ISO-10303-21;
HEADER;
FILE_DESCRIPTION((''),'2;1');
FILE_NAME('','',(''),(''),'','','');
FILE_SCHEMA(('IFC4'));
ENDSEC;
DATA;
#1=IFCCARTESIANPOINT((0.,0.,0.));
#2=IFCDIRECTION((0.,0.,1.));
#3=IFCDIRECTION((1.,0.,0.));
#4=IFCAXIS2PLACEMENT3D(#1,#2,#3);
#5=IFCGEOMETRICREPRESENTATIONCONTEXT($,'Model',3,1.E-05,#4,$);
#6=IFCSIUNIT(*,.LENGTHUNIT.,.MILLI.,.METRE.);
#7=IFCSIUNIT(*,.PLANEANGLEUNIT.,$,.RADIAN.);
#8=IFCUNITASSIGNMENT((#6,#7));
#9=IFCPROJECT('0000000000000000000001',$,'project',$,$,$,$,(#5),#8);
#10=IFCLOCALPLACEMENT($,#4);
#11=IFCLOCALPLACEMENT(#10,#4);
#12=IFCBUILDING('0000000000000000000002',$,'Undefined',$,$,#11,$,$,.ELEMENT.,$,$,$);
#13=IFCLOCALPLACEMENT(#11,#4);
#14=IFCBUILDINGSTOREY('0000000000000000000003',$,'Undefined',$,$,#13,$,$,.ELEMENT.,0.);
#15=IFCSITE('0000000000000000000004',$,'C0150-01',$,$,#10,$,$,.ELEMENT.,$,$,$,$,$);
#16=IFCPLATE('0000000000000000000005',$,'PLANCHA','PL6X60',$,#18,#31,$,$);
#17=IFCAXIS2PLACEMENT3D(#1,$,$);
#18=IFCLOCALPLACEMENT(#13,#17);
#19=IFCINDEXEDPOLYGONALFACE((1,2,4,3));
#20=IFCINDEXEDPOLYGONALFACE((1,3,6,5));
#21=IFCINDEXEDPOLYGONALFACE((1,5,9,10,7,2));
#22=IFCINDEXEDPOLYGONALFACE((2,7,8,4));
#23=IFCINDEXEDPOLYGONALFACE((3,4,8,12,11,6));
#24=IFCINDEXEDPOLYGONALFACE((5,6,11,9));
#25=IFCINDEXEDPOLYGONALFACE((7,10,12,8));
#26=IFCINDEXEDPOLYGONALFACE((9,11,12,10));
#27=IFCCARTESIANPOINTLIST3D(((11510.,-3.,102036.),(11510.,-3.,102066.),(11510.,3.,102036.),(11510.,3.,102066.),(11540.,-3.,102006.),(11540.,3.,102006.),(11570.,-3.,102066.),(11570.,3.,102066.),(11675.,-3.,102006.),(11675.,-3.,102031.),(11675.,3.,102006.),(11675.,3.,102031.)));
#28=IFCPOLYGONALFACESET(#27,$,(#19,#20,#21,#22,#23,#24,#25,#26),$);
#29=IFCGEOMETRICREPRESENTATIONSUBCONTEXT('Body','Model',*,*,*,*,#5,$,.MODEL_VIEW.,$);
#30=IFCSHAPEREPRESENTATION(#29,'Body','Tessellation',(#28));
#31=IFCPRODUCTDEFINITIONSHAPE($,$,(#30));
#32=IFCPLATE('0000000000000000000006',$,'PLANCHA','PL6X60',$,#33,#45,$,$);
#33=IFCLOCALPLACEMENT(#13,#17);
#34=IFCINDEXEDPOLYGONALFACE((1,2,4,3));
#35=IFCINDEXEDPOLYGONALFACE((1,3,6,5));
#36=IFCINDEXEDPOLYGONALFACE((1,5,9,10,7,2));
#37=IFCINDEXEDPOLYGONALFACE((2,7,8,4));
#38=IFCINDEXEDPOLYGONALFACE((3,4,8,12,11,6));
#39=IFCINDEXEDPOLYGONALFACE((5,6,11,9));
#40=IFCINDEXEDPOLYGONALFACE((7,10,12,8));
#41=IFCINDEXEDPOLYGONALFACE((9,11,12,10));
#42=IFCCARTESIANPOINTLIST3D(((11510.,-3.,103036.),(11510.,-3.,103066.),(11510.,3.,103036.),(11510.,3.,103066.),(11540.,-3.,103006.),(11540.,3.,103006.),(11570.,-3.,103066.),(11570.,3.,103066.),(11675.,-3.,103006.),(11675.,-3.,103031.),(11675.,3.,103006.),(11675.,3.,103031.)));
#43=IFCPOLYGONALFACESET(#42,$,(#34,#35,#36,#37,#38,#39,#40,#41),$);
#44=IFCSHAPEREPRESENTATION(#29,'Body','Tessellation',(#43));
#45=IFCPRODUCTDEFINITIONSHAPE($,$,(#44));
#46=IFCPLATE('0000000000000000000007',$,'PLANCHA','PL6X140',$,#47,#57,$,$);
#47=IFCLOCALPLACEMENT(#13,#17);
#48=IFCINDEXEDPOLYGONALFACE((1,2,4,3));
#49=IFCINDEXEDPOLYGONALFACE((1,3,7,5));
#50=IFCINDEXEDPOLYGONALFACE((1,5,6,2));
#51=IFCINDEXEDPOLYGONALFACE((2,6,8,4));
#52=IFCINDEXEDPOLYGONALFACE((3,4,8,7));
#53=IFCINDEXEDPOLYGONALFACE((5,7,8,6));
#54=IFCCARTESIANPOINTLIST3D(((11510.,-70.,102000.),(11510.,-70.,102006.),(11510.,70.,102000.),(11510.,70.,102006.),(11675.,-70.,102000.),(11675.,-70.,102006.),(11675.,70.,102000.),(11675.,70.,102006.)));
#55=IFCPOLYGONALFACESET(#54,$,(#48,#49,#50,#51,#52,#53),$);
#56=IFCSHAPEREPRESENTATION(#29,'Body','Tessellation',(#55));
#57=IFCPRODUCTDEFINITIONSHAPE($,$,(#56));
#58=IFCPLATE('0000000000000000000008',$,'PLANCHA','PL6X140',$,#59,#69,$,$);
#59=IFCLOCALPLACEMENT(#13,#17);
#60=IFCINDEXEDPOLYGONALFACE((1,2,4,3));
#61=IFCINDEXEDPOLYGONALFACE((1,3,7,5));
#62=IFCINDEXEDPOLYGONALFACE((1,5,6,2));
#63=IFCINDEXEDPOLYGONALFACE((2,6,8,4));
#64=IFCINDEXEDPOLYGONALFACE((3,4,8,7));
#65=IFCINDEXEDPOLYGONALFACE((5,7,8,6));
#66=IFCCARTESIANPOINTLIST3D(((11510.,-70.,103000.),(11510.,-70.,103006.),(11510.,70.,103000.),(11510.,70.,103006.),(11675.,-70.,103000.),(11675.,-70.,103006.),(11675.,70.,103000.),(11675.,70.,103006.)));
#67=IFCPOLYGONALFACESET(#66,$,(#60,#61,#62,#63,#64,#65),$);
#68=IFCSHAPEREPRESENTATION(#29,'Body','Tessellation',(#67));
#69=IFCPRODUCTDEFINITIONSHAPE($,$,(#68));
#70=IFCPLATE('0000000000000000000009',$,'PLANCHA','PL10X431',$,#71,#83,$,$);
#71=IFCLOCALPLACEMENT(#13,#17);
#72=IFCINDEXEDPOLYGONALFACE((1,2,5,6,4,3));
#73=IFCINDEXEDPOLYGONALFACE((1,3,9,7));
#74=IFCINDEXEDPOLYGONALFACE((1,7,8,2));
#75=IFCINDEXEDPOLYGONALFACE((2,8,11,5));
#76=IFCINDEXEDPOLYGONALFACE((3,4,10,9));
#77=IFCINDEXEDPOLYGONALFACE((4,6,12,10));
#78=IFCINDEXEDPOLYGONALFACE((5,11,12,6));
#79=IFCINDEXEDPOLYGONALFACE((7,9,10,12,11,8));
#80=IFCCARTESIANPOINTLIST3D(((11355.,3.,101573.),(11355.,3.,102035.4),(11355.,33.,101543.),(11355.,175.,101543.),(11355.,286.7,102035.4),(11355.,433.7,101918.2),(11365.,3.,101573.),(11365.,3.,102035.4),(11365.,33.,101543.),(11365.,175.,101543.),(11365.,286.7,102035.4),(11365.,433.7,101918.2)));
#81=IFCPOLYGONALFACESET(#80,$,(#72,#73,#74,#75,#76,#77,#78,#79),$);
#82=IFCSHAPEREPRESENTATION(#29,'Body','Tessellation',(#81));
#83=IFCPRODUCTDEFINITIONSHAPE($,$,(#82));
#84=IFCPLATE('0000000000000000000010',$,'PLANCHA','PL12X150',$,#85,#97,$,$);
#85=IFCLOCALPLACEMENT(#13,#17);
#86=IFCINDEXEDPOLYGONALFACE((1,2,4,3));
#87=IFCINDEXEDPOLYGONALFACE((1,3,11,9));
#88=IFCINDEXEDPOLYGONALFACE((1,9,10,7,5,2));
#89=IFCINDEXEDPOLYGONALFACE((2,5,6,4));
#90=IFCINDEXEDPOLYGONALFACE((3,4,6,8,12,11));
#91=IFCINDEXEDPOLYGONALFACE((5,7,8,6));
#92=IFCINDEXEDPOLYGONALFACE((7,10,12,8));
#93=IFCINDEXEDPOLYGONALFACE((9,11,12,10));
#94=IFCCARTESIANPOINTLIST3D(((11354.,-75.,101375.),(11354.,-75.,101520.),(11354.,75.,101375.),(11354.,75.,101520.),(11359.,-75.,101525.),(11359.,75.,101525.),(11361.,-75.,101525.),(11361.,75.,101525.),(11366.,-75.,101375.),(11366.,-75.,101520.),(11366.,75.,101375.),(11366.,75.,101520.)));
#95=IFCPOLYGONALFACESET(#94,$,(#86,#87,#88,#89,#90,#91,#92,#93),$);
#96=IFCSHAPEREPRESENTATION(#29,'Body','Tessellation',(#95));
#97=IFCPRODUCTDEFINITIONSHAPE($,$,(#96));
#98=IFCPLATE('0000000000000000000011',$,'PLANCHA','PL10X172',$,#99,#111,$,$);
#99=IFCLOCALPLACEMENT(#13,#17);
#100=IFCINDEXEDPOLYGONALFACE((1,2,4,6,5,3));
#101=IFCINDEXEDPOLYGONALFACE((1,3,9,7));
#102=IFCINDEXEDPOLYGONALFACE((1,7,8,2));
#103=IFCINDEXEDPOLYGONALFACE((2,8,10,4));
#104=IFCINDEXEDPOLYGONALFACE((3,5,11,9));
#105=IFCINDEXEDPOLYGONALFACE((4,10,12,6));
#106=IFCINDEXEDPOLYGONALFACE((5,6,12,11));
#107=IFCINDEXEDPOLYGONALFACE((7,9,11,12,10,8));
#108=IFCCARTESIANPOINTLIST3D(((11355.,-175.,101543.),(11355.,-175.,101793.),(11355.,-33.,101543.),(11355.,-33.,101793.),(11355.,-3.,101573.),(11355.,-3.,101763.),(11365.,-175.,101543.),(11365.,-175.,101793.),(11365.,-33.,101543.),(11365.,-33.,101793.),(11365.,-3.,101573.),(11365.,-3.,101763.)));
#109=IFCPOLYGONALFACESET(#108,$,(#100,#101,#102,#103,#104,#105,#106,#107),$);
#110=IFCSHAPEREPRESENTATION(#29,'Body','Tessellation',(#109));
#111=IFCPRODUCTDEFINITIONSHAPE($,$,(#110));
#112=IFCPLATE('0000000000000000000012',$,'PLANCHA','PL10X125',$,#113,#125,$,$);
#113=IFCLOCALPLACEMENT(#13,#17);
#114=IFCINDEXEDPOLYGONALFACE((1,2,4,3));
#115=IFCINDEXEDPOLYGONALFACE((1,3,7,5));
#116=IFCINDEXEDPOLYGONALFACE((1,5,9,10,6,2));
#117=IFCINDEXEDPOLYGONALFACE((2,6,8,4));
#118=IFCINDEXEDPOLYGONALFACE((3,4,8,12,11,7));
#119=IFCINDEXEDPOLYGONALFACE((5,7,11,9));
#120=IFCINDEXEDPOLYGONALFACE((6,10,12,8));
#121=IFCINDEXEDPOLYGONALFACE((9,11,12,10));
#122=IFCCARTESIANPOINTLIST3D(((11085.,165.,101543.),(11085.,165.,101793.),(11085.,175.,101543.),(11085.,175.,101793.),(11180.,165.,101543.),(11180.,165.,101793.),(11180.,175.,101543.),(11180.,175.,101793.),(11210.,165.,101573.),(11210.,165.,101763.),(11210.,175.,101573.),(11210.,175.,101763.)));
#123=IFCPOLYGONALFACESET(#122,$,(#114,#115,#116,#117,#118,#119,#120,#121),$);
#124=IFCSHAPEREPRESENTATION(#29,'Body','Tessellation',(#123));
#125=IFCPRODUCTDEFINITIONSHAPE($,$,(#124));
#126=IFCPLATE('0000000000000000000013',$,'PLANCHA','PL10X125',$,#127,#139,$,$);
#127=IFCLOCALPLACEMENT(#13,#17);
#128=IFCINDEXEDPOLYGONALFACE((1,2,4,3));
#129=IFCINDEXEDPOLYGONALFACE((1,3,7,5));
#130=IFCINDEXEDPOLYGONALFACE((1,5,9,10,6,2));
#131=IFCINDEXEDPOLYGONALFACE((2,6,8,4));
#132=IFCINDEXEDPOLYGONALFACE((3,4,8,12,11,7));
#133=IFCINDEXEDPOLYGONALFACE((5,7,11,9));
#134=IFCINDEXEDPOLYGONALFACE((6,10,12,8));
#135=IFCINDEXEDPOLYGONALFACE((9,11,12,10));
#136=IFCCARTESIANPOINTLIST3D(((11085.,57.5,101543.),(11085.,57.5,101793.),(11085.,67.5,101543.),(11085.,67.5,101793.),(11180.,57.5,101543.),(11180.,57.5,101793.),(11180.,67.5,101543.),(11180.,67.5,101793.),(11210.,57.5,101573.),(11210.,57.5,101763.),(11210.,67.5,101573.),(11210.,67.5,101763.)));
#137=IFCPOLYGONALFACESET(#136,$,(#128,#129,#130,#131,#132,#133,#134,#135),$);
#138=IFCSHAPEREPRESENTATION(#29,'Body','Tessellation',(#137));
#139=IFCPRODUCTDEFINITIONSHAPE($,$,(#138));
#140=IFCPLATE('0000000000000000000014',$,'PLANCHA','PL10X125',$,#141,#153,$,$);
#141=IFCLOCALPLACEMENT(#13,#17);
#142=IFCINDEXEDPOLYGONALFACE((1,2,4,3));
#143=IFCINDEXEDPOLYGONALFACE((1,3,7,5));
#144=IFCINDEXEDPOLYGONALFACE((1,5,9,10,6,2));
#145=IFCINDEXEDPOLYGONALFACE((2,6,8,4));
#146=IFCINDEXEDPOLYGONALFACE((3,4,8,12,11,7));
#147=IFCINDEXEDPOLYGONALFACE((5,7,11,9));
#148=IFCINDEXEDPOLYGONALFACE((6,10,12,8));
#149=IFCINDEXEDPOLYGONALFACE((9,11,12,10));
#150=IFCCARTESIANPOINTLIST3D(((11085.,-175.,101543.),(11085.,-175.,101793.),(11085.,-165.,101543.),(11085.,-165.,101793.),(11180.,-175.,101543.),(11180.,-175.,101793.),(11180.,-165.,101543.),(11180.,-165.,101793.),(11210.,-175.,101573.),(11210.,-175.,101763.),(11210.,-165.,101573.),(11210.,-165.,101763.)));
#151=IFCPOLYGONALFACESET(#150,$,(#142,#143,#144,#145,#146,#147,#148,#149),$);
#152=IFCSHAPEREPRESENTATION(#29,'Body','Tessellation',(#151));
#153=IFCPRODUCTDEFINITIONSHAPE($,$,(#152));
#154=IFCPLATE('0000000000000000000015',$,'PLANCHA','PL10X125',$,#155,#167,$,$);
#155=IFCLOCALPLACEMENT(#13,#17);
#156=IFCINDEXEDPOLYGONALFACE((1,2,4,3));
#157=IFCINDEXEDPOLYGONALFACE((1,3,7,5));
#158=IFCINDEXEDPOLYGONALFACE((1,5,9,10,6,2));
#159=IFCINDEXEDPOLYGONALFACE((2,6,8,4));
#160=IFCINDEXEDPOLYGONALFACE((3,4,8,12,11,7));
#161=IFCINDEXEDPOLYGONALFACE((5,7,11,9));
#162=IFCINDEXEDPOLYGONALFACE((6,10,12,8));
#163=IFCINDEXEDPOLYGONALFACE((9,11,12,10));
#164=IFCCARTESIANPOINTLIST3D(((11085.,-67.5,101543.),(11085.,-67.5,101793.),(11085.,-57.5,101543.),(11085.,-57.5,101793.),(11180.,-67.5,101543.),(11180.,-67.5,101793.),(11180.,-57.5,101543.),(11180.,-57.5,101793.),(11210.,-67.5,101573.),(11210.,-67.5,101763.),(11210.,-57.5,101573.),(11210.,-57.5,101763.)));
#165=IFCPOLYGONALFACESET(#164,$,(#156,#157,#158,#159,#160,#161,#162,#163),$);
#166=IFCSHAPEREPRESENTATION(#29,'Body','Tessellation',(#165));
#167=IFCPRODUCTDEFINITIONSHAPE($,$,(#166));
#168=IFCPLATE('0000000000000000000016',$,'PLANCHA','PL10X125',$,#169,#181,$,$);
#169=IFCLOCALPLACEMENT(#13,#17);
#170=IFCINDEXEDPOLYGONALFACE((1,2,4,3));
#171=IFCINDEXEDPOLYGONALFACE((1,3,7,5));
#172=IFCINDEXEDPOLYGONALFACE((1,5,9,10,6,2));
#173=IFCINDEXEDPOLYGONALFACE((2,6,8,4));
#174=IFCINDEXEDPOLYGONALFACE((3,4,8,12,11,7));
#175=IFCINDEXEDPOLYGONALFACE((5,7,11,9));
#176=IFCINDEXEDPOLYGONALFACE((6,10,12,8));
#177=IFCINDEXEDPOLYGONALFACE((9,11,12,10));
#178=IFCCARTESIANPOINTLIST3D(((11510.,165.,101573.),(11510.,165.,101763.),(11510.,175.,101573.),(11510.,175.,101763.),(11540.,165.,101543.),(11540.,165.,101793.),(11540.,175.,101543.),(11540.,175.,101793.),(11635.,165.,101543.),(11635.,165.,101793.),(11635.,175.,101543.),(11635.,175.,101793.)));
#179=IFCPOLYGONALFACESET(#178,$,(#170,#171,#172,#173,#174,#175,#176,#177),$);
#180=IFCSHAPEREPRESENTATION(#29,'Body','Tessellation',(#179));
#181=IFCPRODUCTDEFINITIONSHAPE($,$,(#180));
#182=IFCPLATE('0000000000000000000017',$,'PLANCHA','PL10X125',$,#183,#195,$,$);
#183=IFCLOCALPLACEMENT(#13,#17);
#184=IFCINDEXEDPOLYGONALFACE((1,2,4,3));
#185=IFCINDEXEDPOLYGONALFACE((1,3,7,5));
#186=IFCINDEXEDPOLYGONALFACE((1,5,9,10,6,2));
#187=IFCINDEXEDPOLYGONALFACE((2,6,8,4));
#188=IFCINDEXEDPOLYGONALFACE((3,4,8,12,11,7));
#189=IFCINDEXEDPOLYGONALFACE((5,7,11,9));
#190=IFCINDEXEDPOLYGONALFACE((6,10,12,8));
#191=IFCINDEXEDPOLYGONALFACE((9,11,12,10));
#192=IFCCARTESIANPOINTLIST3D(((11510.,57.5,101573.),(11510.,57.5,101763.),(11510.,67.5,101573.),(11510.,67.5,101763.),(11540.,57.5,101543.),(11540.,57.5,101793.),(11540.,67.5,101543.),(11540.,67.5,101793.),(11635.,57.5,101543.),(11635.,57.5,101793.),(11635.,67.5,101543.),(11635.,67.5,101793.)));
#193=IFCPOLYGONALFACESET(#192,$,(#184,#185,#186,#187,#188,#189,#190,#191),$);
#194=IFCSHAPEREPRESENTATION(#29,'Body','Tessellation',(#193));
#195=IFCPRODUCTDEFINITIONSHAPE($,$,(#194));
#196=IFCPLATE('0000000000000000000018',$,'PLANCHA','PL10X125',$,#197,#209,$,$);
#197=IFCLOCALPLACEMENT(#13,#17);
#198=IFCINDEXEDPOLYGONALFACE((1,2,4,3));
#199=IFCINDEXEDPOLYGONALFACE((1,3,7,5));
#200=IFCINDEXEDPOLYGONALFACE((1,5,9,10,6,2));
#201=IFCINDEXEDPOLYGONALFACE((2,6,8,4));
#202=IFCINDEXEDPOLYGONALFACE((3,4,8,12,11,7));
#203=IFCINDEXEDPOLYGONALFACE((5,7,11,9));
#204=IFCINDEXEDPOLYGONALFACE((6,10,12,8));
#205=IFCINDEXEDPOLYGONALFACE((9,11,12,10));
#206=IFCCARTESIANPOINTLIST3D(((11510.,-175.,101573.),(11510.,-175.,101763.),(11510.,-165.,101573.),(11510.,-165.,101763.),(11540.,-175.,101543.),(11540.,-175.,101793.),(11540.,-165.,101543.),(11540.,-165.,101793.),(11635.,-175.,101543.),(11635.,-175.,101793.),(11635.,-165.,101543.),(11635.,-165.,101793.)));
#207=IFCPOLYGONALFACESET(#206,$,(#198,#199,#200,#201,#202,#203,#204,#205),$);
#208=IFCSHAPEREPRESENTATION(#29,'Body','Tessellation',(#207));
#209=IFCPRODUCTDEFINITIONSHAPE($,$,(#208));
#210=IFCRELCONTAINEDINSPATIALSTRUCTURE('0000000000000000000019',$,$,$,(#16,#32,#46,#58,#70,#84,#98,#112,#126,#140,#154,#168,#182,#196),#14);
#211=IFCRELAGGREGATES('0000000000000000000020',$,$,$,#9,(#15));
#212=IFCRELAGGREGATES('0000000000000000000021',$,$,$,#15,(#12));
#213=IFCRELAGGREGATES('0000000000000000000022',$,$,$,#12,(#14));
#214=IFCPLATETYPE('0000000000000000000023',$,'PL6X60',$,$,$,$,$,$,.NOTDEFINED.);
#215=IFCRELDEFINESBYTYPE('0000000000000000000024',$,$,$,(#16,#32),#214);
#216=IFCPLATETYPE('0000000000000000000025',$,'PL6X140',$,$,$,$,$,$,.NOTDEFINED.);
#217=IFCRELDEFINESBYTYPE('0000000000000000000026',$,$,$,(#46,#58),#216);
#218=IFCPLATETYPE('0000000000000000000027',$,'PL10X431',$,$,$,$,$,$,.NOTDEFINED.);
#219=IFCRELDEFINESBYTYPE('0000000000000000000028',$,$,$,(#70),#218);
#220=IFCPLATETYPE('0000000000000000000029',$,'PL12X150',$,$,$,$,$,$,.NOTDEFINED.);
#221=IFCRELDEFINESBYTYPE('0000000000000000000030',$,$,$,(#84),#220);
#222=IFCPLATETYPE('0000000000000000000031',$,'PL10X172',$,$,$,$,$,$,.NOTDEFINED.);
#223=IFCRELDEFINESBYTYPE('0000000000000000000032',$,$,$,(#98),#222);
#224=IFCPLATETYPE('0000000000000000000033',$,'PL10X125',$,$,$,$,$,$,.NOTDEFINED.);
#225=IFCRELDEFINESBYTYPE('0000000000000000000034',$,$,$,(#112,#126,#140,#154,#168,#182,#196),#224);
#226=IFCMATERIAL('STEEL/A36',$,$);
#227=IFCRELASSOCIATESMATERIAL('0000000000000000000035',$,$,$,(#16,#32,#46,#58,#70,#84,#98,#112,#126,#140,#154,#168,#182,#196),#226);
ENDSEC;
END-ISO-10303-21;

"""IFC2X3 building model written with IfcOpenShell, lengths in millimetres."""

from ifc_helpers import new_model, si_unit, frame, origin_with_axes, place, context, subcontext, project, spatial, polyline, outline, extrude, boolean, material, type_object, element, save


model = new_model("IFC2X3")

# Units and contexts
model_context = context("Model", 3, precision=1e-05, world=origin_with_axes())
body_context = subcontext(model_context, "Body", "Model", "MODEL_VIEW")
ifc_project = project(units=[si_unit("LENGTHUNIT", "METRE", prefix="MILLI"), si_unit("PLANEANGLEUNIT", "RADIAN")], contexts=[model_context])

# Site, building, storey
site_placement = place(None, origin_with_axes())
site = spatial("IfcSite", under=ifc_project, at=site_placement, Name="C0150-01", CompositionType="ELEMENT")
building_placement = place(site_placement, origin_with_axes())
building = spatial("IfcBuilding", under=site, at=building_placement, Name="Undefined", CompositionType="ELEMENT")
storey_placement = place(building_placement, origin_with_axes())
storey = spatial("IfcBuildingStorey", under=building, at=storey_placement, Name="Undefined", CompositionType="ELEMENT", Elevation=0.0)

# Shared definitions
ifc_material_1 = material(Name="STEEL/A36")

# Plates
plate_type_1 = type_object("IfcPlateType", Name="PL6X60", PredefinedType="NOTDEFINED")
for number, where, z_axis, x_axis, name in (
    (1, (11675.0, 0.0, 102031.0), (0.0, 1.0, 0.0), (0.000005, 0.0, -1.0), "PLANCHA"),
    (2, (11675.0, 0.0, 103031.0), (0.0, 1.0, 0.0), (0.000005, 0.0, -1.0), "PLANCHA"),
):
    element("IfcPlate", number, at=place(storey_placement, frame(where, z_axis=z_axis, x_axis=x_axis)), inside=storey, type_object=plate_type_1, material=ifc_material_1, Name=name, Description="PL6X60", context=body_context, shape_type="SweptSolid", body=[
        extrude(outline(polyline([(0.0, 0.0), (25.0, 0.0), (25.0, 135.0), (-5.0, 165.0), (-35.0, 165.0), (-35.0, 105.0), (0.0, 0.0)])), frame((0.0, 0.0, -3.0), z_axis=(0.0, 0.0, 1.0), x_axis=(1.0, 0.0, 0.0)), (0.0, 0.0, 1.0), 6.0),
    ])
plate_type_2 = type_object("IfcPlateType", Name="PL6X140", PredefinedType="NOTDEFINED")
for number, where, z_axis, x_axis, name in (
    (3, (11510.0, 70.0, 102003.0), (-0.000004, 0.0, 1.0), (0.0, -1.0, 0.0), "PLANCHA"),
    (4, (11510.0, 70.0, 103003.0), (-0.000004, 0.0, 1.0), (0.0, -1.0, 0.0), "PLANCHA"),
):
    element("IfcPlate", number, at=place(storey_placement, frame(where, z_axis=z_axis, x_axis=x_axis)), inside=storey, type_object=plate_type_2, material=ifc_material_1, Name=name, Description="PL6X140", context=body_context, shape_type="SweptSolid", body=[
        extrude(outline(polyline([(0.0, 0.0), (140.0, 0.0), (140.0, 165.0), (0.0, 165.0), (0.0, 0.0)])), frame((0.0, 0.0, -3.0), z_axis=(0.0, 0.0, 1.0), x_axis=(1.0, 0.0, 0.0)), (0.0, 0.0, 1.0), 6.0),
    ])
plate_type_3 = type_object("IfcPlateType", Name="PL10X431", PredefinedType="NOTDEFINED")
plate_1_placement = place(storey_placement, frame((11360.0, 433.7, 101918.2), z_axis=(-1.0, 0.0, 0.0), x_axis=(0.0, -0.567638, -0.823279)))
element("IfcPlate", 5, at=plate_1_placement, inside=storey, type_object=plate_type_3, material=ifc_material_1, Name="PLANCHA", Description="PL10X431", context=body_context, shape_type="SweptSolid", body=[
    extrude(outline(polyline([(0.0, 0.0), (455.8, 0.0), (536.4, 116.9), (528.7, 158.6), (148.0, 421.1), (-13.0, 187.5), (0.0, 0.0)])), frame((0.0, 0.0, -5.0), z_axis=(0.0, 0.0, 1.0), x_axis=(1.0, 0.0, 0.0)), (0.0, 0.0, 1.0), 10.0),
])
plate_type_4 = type_object("IfcPlateType", Name="PL12X150", PredefinedType="NOTDEFINED")
plate_2_placement = place(storey_placement, frame((11360.0, 75.0, 101525.0), z_axis=(-1.0, 0.0, 0.0), x_axis=(0.0, 0.0, -1.0)))
element("IfcPlate", 6, at=plate_2_placement, inside=storey, type_object=plate_type_4, material=ifc_material_1, Name="PLANCHA", Description="PL12X150", context=body_context, shape_type="CSG", body=[
    boolean("DIFFERENCE", boolean("DIFFERENCE", extrude(outline(polyline([(0.0, 0.0), (150.0, 0.0), (150.0, 150.0), (0.0, 150.0), (0.0, 0.0)])), frame((0.0, 0.0, -6.0), z_axis=(0.0, 0.0, 1.0), x_axis=(1.0, 0.0, 0.0)), (0.0, 0.0, 1.0), 12.0), extrude(outline(polyline([(0.0, 0.0), (5.0, 0.0), (5.0, 5.0), (0.0, 0.0)])), frame((5.0, 152.5, 6.0), z_axis=(0.0, -1.0, 0.0), x_axis=(-1.0, 0.0, 0.0)), (0.0, 0.0, 1.0), 155.0)), extrude(outline(polyline([(0.0, 0.0), (5.0, 0.0), (5.0, 5.0), (0.0, 0.0)])), frame((5.0, -2.5, -6.0), z_axis=(0.0, 1.0, 0.0), x_axis=(-1.0, 0.0, 0.0)), (0.0, 0.0, 1.0), 155.0)),
])
plate_type_5 = type_object("IfcPlateType", Name="PL10X172", PredefinedType="NOTDEFINED")
plate_3_placement = place(storey_placement, frame((11360.0, -175.0, 101793.0), z_axis=(1.0, 0.0, 0.0), x_axis=(0.0, 0.0, -1.0)))
element("IfcPlate", 7, at=plate_3_placement, inside=storey, type_object=plate_type_5, material=ifc_material_1, Name="PLANCHA", Description="PL10X172", context=body_context, shape_type="SweptSolid", body=[
    extrude(outline(polyline([(0.0, 0.0), (250.0, 0.0), (250.0, 142.0), (220.0, 172.0), (30.0, 172.0), (0.0, 142.0), (0.0, 0.0)])), frame((0.0, 0.0, -5.0), z_axis=(0.0, 0.0, 1.0), x_axis=(1.0, 0.0, 0.0)), (0.0, 0.0, 1.0), 10.0),
])
plate_type_6 = type_object("IfcPlateType", Name="PL10X125", PredefinedType="NOTDEFINED")
for number, where, z_axis, x_axis, name in (
    (8, (11085.0, 170.0, 101793.0), (0.0, -1.0, 0.0), (0.0, 0.0, -1.0), "PLANCHA"),
    (9, (11085.0, 62.5, 101793.0), (0.0, -1.0, 0.0), (0.0, 0.0, -1.0), "PLANCHA"),
    (10, (11085.0, -170.0, 101793.0), (0.0, -1.0, 0.0), (0.0, 0.0, -1.0), "PLANCHA"),
    (11, (11085.0, -62.5, 101793.0), (0.0, -1.0, 0.0), (0.0, 0.0, -1.0), "PLANCHA"),
    (12, (11635.0, 170.0, 101793.0), (0.0, 1.0, 0.0), (0.0, 0.0, -1.0), "PLANCHA"),
    (13, (11635.0, 62.5, 101793.0), (0.0, 1.0, 0.0), (0.0, 0.0, -1.0), "PLANCHA"),
    (14, (11635.0, -170.0, 101793.0), (0.0, 1.0, 0.0), (0.0, 0.0, -1.0), "PLANCHA"),
):
    element("IfcPlate", number, at=place(storey_placement, frame(where, z_axis=z_axis, x_axis=x_axis)), inside=storey, type_object=plate_type_6, material=ifc_material_1, Name=name, Description="PL10X125", context=body_context, shape_type="SweptSolid", body=[
        extrude(outline(polyline([(0.0, 0.0), (250.0, 0.0), (250.0, 95.0), (220.0, 125.0), (30.0, 125.0), (0.0, 95.0), (0.0, 0.0)])), frame((0.0, 0.0, -5.0), z_axis=(0.0, 0.0, 1.0), x_axis=(1.0, 0.0, 0.0)), (0.0, 0.0, 1.0), 10.0),
    ])

save(model, "model.ifc")
